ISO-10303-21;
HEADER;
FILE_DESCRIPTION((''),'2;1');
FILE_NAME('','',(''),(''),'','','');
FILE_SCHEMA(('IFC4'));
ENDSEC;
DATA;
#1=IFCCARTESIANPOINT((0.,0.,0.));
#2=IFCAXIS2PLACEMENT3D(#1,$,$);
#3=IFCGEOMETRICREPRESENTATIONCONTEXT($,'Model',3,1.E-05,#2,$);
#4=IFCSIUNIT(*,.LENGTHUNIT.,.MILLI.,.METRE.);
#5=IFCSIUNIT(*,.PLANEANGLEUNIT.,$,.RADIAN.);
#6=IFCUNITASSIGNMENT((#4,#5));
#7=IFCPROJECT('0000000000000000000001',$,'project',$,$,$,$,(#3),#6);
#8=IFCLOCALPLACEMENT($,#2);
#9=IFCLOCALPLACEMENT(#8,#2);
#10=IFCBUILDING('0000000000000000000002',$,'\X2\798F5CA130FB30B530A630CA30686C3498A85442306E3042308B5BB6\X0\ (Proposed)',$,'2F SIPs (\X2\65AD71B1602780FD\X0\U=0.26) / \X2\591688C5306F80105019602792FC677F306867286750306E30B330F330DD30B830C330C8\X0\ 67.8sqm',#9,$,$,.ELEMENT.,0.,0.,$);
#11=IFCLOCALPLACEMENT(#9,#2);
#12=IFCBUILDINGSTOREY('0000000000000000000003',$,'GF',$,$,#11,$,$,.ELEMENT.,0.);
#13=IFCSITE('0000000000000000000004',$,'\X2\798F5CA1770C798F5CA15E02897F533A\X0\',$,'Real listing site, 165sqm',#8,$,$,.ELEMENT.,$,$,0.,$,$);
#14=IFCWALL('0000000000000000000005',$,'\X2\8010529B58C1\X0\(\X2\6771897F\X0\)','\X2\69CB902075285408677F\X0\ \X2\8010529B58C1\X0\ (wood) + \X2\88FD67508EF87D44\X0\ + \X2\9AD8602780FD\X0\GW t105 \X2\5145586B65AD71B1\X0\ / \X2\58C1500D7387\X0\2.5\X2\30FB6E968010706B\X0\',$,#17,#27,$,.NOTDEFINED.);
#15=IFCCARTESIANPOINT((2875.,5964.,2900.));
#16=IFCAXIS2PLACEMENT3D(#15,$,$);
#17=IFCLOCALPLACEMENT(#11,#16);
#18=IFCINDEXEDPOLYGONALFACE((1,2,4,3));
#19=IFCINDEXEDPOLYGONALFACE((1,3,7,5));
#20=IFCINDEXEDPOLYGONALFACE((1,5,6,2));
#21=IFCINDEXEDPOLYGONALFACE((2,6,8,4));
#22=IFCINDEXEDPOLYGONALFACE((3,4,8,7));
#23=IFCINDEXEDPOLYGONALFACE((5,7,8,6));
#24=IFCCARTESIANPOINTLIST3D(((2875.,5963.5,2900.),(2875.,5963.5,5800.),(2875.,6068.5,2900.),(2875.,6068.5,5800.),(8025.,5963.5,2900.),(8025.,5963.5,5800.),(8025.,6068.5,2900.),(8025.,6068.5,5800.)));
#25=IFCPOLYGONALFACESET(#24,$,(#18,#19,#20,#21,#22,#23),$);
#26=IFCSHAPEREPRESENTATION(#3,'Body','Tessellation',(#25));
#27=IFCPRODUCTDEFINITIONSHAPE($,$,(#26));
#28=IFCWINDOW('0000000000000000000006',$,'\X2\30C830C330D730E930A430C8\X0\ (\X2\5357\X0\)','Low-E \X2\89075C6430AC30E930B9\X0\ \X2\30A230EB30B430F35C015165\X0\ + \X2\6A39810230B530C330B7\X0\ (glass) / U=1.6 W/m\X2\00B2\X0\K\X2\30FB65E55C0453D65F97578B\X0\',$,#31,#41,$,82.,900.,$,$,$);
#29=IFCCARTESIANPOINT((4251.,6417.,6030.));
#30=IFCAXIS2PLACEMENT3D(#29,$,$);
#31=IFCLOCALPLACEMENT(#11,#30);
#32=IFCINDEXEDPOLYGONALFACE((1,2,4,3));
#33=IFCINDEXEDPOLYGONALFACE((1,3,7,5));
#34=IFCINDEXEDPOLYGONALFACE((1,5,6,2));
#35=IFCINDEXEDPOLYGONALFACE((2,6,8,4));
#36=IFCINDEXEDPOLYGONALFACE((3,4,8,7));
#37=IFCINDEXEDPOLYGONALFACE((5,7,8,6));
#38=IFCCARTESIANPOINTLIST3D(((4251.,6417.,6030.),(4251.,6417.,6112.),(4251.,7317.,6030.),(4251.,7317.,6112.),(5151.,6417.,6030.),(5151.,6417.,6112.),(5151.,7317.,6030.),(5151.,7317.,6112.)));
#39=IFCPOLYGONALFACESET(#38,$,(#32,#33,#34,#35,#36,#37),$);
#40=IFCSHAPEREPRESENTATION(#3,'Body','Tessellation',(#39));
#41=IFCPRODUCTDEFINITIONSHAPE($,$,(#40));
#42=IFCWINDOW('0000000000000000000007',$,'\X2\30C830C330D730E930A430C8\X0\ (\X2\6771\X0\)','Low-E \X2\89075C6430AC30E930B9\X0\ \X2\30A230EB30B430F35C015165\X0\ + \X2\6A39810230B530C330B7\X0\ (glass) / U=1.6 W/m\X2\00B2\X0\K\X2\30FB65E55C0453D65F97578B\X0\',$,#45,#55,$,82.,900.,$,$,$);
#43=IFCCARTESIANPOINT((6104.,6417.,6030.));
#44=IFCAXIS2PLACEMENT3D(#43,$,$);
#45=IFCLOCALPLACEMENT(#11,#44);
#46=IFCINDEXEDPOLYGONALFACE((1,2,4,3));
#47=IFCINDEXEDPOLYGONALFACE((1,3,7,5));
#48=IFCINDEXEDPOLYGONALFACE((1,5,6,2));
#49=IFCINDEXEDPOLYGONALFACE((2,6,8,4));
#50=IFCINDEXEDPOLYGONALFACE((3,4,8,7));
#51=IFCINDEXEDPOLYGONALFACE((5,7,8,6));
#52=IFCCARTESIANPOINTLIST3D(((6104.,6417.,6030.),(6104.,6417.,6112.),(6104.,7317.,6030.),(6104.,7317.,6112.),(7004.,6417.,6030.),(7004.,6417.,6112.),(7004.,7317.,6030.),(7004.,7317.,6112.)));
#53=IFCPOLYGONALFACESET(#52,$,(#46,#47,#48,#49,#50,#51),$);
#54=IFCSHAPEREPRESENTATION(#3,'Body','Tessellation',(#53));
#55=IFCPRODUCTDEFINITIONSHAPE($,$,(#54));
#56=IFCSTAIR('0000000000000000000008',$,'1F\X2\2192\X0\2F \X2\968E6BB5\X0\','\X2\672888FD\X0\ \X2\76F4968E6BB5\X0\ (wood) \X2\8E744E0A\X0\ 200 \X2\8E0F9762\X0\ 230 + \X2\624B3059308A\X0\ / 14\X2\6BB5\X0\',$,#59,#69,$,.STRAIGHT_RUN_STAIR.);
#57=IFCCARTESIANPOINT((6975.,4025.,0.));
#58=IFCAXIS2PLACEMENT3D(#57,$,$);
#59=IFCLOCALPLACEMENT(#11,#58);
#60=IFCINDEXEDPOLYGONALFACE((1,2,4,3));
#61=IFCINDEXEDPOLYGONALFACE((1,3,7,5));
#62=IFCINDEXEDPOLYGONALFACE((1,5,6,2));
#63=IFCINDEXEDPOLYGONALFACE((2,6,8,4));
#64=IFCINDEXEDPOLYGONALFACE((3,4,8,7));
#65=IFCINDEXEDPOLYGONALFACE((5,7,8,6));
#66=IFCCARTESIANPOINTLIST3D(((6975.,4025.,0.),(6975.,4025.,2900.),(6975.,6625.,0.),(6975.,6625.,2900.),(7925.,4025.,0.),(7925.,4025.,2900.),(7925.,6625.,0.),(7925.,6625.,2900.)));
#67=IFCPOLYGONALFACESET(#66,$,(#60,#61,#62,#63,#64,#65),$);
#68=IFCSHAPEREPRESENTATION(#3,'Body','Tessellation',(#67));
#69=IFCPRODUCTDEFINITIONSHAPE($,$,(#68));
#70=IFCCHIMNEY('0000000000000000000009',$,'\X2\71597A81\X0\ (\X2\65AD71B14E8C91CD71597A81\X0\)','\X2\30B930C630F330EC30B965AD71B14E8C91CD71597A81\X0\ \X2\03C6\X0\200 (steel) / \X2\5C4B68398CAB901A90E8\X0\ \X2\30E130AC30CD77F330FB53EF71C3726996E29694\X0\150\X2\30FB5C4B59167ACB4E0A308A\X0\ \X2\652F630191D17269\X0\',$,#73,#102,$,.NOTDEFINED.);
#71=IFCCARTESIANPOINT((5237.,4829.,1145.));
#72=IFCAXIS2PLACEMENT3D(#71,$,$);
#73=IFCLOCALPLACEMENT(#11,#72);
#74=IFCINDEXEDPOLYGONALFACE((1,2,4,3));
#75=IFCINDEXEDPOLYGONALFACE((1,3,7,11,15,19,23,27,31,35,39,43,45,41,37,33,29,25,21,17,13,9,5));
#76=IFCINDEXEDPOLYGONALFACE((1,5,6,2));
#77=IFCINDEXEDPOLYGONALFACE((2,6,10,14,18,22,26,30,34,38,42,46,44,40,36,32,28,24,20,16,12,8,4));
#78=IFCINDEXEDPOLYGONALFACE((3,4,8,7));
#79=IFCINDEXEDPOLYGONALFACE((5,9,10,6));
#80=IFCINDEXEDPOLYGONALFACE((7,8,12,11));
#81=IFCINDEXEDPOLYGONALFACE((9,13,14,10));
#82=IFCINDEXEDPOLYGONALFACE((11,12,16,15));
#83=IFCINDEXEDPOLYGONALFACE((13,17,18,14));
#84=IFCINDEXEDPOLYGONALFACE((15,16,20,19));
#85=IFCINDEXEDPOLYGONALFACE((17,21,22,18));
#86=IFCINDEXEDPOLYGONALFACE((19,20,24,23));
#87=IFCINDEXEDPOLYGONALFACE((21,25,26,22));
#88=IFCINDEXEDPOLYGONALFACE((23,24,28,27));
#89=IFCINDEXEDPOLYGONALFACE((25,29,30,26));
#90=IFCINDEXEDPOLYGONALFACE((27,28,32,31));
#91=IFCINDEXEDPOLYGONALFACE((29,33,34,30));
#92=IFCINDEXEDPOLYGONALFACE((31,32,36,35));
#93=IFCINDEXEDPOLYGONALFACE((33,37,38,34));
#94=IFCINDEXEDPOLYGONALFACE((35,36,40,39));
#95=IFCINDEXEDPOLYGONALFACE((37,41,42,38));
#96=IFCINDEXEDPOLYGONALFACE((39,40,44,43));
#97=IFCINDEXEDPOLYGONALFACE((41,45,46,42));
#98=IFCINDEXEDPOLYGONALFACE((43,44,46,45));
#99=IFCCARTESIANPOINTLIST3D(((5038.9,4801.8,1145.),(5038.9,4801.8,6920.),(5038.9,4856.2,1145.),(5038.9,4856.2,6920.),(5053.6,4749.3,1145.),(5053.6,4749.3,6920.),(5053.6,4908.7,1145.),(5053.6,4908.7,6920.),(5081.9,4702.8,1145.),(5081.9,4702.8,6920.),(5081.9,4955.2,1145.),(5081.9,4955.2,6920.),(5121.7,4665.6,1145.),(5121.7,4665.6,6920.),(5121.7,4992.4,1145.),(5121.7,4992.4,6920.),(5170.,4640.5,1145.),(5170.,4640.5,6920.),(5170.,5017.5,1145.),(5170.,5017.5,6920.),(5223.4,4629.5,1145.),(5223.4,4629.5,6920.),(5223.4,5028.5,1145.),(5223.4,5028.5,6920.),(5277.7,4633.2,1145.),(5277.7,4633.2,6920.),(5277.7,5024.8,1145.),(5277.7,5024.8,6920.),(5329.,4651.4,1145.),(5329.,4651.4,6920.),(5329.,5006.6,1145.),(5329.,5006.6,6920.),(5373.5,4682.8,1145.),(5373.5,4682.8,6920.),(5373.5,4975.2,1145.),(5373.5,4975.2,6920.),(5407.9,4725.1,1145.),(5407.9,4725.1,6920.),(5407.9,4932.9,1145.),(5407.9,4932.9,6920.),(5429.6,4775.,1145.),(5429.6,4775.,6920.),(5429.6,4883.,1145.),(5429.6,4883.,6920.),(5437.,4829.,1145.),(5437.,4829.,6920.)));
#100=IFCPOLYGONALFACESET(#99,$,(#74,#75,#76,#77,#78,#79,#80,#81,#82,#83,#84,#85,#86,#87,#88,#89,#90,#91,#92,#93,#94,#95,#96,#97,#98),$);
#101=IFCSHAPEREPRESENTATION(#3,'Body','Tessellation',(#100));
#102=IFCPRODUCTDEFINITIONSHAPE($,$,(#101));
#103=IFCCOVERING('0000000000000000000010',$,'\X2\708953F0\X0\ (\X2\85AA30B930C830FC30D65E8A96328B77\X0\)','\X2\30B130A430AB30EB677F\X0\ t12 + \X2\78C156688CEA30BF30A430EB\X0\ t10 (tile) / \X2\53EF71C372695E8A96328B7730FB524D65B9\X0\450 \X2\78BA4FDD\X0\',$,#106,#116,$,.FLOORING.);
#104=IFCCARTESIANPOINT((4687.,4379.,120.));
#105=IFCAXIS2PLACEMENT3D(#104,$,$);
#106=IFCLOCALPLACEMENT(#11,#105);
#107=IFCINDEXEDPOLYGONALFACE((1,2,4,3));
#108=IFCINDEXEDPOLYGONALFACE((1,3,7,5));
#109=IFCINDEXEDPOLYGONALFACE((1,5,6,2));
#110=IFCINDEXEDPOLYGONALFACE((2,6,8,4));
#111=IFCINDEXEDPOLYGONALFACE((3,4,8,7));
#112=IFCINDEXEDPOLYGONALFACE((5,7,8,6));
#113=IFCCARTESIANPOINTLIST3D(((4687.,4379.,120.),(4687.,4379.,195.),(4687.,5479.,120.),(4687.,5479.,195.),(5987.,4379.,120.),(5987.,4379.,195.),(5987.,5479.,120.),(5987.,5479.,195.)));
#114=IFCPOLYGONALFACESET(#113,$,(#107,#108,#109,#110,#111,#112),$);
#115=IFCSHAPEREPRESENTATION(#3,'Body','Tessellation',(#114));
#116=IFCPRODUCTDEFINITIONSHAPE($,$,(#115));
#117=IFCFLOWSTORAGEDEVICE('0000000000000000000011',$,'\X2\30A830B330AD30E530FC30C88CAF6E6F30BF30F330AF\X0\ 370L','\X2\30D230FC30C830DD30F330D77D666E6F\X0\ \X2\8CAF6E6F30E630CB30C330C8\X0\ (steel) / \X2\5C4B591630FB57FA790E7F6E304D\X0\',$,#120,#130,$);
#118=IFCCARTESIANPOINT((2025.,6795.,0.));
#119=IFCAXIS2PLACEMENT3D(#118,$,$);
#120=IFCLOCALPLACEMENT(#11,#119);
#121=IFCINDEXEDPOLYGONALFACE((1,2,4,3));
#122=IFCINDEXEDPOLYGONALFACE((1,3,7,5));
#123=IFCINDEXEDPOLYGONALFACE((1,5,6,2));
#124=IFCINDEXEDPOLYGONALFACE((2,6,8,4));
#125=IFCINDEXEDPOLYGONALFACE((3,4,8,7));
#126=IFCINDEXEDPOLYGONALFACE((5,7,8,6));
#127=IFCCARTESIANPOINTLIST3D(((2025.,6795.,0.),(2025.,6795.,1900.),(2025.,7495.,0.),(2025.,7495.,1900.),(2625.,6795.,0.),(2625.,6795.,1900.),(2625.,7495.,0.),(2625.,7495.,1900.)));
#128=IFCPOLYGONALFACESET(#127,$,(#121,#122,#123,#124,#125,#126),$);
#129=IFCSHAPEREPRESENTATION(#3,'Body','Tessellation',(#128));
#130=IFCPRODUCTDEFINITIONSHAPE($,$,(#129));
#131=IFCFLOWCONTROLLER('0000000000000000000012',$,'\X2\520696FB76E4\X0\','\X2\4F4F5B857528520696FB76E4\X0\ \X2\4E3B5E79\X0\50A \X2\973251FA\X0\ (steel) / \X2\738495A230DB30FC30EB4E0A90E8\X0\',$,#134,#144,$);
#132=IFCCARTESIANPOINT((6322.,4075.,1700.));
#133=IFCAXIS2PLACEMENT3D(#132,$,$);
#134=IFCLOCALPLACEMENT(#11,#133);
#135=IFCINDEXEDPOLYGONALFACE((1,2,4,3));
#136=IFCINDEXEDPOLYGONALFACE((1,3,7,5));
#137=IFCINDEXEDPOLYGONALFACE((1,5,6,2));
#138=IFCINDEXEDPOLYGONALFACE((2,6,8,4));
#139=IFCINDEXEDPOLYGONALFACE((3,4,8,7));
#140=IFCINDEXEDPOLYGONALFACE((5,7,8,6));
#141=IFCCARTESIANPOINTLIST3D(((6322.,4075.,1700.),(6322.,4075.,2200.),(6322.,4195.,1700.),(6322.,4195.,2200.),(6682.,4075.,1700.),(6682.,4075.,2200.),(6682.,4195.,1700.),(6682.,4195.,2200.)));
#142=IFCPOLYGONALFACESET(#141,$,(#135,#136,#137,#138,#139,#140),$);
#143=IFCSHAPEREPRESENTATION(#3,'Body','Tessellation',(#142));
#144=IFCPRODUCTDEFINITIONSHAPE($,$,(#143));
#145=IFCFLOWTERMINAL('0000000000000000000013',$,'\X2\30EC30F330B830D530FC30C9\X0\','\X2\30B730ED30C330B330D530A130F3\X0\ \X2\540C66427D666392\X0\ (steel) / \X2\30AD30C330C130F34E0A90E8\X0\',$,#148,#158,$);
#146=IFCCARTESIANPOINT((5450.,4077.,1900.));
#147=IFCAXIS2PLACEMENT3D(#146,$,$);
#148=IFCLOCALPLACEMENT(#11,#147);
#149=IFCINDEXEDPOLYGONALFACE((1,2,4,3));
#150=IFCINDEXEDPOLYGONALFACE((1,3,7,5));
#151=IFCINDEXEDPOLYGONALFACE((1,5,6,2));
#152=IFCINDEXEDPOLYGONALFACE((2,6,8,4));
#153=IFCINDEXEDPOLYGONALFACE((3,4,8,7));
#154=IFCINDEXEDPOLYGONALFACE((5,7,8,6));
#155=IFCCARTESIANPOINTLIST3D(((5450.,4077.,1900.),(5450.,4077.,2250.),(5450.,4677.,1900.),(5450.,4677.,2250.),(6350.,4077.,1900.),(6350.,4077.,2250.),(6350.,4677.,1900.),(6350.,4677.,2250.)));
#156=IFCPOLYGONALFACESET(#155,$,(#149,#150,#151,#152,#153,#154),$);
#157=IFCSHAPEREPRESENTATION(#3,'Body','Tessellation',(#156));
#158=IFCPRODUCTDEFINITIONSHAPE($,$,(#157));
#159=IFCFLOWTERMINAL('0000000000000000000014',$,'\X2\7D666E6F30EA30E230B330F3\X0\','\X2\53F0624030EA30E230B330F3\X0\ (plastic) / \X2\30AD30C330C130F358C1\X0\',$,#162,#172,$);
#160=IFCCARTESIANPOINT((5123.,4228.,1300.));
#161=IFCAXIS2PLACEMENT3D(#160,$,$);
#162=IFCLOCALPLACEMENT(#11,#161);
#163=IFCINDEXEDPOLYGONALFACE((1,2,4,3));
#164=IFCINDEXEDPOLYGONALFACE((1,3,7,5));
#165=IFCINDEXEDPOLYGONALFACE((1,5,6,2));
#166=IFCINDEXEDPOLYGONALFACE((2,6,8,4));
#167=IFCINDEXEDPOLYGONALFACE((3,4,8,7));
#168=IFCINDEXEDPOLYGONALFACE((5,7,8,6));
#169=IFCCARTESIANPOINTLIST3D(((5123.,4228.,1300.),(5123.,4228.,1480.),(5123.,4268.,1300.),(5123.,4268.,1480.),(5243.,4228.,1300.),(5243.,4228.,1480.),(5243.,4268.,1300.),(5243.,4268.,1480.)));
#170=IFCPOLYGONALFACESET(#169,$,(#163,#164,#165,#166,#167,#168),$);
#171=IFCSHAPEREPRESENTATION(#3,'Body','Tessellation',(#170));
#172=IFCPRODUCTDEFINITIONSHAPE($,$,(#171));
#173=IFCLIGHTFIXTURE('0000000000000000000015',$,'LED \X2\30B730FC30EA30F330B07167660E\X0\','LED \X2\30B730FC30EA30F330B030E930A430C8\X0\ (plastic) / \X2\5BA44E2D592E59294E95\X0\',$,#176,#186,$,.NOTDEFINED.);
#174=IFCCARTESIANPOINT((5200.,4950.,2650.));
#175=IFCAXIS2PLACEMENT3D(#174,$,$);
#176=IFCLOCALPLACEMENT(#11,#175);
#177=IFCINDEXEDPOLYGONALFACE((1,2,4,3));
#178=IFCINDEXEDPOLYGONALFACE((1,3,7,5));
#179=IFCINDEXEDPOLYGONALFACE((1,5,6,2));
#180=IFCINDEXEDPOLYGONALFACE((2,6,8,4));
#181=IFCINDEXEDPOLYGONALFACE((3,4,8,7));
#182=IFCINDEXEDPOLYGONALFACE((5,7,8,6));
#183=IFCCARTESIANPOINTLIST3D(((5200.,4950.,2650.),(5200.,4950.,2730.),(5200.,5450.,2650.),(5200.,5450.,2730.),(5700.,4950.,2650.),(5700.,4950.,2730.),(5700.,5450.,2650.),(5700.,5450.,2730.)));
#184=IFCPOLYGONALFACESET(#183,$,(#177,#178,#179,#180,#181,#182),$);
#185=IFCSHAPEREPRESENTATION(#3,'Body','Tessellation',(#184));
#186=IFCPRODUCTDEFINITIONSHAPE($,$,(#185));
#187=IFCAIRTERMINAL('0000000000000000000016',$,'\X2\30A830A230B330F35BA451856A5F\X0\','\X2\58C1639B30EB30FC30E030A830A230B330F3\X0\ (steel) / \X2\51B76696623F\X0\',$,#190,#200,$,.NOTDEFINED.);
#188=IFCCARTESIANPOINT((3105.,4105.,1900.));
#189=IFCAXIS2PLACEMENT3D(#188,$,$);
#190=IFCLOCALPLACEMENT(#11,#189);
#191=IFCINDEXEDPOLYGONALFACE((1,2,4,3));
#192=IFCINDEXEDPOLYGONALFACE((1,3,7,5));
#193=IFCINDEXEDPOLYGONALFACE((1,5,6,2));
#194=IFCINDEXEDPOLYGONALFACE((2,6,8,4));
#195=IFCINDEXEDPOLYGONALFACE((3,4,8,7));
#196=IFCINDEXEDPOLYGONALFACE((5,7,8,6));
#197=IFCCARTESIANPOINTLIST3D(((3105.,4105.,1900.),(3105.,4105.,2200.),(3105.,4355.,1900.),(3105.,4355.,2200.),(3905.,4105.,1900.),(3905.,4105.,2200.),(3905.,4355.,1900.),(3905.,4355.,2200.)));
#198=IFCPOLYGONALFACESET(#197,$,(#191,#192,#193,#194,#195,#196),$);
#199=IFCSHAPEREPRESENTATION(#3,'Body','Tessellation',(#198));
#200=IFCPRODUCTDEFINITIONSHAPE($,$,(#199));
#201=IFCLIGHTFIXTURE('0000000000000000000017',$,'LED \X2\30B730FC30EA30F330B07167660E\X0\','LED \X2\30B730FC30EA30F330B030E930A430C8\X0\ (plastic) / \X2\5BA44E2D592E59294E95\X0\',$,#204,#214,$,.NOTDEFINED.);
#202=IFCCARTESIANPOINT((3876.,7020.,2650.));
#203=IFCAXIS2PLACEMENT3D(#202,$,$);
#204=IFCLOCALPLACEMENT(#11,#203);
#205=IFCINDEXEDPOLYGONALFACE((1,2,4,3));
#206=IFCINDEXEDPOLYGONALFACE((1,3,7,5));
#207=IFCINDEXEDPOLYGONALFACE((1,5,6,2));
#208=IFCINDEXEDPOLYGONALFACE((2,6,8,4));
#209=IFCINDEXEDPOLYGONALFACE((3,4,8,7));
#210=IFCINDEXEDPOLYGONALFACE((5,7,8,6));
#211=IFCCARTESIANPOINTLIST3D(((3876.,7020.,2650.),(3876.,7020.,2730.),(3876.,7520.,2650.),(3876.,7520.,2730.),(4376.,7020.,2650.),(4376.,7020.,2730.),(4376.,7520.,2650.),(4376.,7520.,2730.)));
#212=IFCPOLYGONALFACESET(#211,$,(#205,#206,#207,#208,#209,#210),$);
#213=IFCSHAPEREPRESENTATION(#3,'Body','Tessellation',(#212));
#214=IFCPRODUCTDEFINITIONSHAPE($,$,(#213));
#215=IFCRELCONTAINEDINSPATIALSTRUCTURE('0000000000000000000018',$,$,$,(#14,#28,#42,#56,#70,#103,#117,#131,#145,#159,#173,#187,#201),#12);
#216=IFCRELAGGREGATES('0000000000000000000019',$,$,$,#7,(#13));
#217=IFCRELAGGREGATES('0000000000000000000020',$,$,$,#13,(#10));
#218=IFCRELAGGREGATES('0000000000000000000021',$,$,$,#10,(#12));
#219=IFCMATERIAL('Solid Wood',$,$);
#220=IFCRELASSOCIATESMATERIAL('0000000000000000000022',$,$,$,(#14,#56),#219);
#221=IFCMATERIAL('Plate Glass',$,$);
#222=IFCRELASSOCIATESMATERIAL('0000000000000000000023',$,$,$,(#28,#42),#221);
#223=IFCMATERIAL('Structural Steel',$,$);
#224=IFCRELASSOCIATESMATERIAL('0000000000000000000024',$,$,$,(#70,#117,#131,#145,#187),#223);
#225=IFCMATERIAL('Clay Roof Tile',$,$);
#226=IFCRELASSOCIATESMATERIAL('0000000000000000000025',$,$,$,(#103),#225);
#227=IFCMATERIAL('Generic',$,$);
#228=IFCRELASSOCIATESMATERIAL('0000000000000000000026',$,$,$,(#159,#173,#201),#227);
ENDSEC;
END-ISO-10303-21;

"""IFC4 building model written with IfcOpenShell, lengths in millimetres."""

from ifc_helpers import new_model, si_unit, frame, frame_2d, origin, origin_2d, place, context, project, spatial, rectangle, circle, extrude, material, element, save


model = new_model("IFC4")

# Units and contexts
model_context = context("Model", 3, precision=1e-05, world=origin())
ifc_project = project(units=[si_unit("LENGTHUNIT", "METRE", prefix="MILLI"), si_unit("PLANEANGLEUNIT", "RADIAN")], contexts=[model_context])

# Site, building, storey
site_placement = place(None, origin())
site = spatial("IfcSite", under=ifc_project, at=site_placement, Name="福岡県福岡市西区", ObjectType="Real listing site, 165sqm", CompositionType="ELEMENT", RefElevation=0.0)
building_placement = place(site_placement, origin())
building = spatial("IfcBuilding", under=site, at=building_placement, Name="福岡・サウナと水風呂のある家 (Proposed)", ObjectType="2F SIPs (断熱性能U=0.26) / 外装は耐候性鋼板と木材のコンポジット 67.8sqm", CompositionType="ELEMENT", ElevationOfRefHeight=0.0, ElevationOfTerrain=0.0)
storey_placement = place(building_placement, origin())
storey = spatial("IfcBuildingStorey", under=building, at=storey_placement, Name="GF", CompositionType="ELEMENT", Elevation=0.0)

# Shared definitions
ifc_material_1 = material(Name="Solid Wood")

# Wall
wall_1_placement = place(storey_placement, frame((2875.0, 5964.0, 2900.0)))
element("IfcWall", 1, at=wall_1_placement, inside=storey, material=ifc_material_1, Name="耐力壁(東西)", Description="構造用合板 耐力壁 (wood) + 製材軸組 + 高性能GW t105 充填断熱 / 壁倍率2.5・準耐火", PredefinedType="NOTDEFINED", context=model_context, shape_type="SweptSolid", body=[
    extrude(rectangle(XDim=5150.0, YDim=105.0, at=frame_2d((2575.0, 52.0))), frame((2875.0, 5964.0, 2900.0)), (0.0, 0.0, 1.0), 2900.0),
])

# Windows
ifc_material_2 = material(Name="Plate Glass")
window_1_placement = place(storey_placement, frame((4251.0, 6417.0, 6030.0)))
element("IfcWindow", 2, at=window_1_placement, inside=storey, material=ifc_material_2, Name="トップライト (南)", Description="Low-E 複層ガラス アルゴン封入 + 樹脂サッシ (glass) / U=1.6 W/m²K・日射取得型", OverallHeight=82.0, OverallWidth=900.0, context=model_context, shape_type="SweptSolid", body=[
    extrude(rectangle(XDim=900.0, YDim=900.0, at=frame_2d((450.0, 450.0))), frame((4251.0, 6417.0, 6030.0)), (0.0, 0.0, 1.0), 82.0),
])
window_2_placement = place(storey_placement, frame((6104.0, 6417.0, 6030.0)))
element("IfcWindow", 3, at=window_2_placement, inside=storey, material=ifc_material_2, Name="トップライト (東)", Description="Low-E 複層ガラス アルゴン封入 + 樹脂サッシ (glass) / U=1.6 W/m²K・日射取得型", OverallHeight=82.0, OverallWidth=900.0, context=model_context, shape_type="SweptSolid", body=[
    extrude(rectangle(XDim=900.0, YDim=900.0, at=frame_2d((450.0, 450.0))), frame((6104.0, 6417.0, 6030.0)), (0.0, 0.0, 1.0), 82.0),
])

# Stair
stair_placement = place(storey_placement, frame((6975.0, 4025.0, 0.0)))
element("IfcStair", 4, at=stair_placement, inside=storey, material=ifc_material_1, Name="1F→2F 階段", Description="木製 直階段 (wood) 蹴上 200 踏面 230 + 手すり / 14段", PredefinedType="STRAIGHT_RUN_STAIR", context=model_context, shape_type="SweptSolid", body=[
    extrude(rectangle(XDim=950.0, YDim=2600.0, at=frame_2d((475.0, 1300.0))), frame((6975.0, 4025.0, 0.0)), (0.0, 0.0, 1.0), 2900.0),
])

# Chimney
ifc_material_3 = material(Name="Structural Steel")
chimney_placement = place(storey_placement, frame((5237.0, 4829.0, 1145.0)))
element("IfcChimney", 5, at=chimney_placement, inside=storey, material=ifc_material_3, Name="煙突 (断熱二重煙突)", Description="ステンレス断熱二重煙突 φ200 (steel) / 屋根貫通部 メガネ石・可燃物離隔150・屋外立上り 支持金物", PredefinedType="NOTDEFINED", context=model_context, shape_type="SweptSolid", body=[
    extrude(circle(Radius=200.0, at=origin_2d()), frame((5237.0, 4829.0, 1145.0)), (0.0, 0.0, 1.0), 5775.0),
])

# Covering
ifc_material_4 = material(Name="Clay Roof Tile")
covering_placement = place(storey_placement, frame((4687.0, 4379.0, 120.0)))
element("IfcCovering", 6, at=covering_placement, inside=storey, material=ifc_material_4, Name="炉台 (薪ストーブ床防護)", Description="ケイカル板 t12 + 磁器質タイル t10 (tile) / 可燃物床防護・前方450 確保", PredefinedType="FLOORING", context=model_context, shape_type="SweptSolid", body=[
    extrude(rectangle(XDim=1300.0, YDim=1100.0, at=frame_2d((650.0, 550.0))), frame((4687.0, 4379.0, 120.0)), (0.0, 0.0, 1.0), 75.0),
])

# Flow storage device
flow_storage_device_placement = place(storey_placement, frame((2025.0, 6795.0, 0.0)))
element("IfcFlowStorageDevice", 7, at=flow_storage_device_placement, inside=storey, material=ifc_material_3, Name="エコキュート貯湯タンク 370L", Description="ヒートポンプ給湯 貯湯ユニット (steel) / 屋外・基礎置き", context=model_context, shape_type="SweptSolid", body=[
    extrude(rectangle(XDim=600.0, YDim=700.0, at=frame_2d((300.0, 350.0))), frame((2025.0, 6795.0, 0.0)), (0.0, 0.0, 1.0), 1900.0),
])

# Flow controller
flow_controller_placement = place(storey_placement, frame((6322.0, 4075.0, 1700.0)))
element("IfcFlowController", 8, at=flow_controller_placement, inside=storey, material=ifc_material_3, Name="分電盤", Description="住宅用分電盤 主幹50A 露出 (steel) / 玄関ホール上部", context=model_context, shape_type="SweptSolid", body=[
    extrude(rectangle(XDim=360.0, YDim=120.0, at=frame_2d((180.0, 60.0))), frame((6322.0, 4075.0, 1700.0)), (0.0, 0.0, 1.0), 500.0),
])

# Flow terminals
flow_terminal_1_placement = place(storey_placement, frame((5450.0, 4077.0, 1900.0)))
element("IfcFlowTerminal", 9, at=flow_terminal_1_placement, inside=storey, material=ifc_material_3, Name="レンジフード", Description="シロッコファン 同時給排 (steel) / キッチン上部", context=model_context, shape_type="SweptSolid", body=[
    extrude(rectangle(XDim=900.0, YDim=600.0, at=frame_2d((450.0, 300.0))), frame((5450.0, 4077.0, 1900.0)), (0.0, 0.0, 1.0), 350.0),
])
ifc_material_5 = material(Name="Generic")
flow_terminal_2_placement = place(storey_placement, frame((5123.0, 4228.0, 1300.0)))
element("IfcFlowTerminal", 10, at=flow_terminal_2_placement, inside=storey, material=ifc_material_5, Name="給湯リモコン", Description="台所リモコン (plastic) / キッチン壁", context=model_context, shape_type="SweptSolid", body=[
    extrude(rectangle(XDim=120.0, YDim=40.0, at=frame_2d((60.0, 20.0))), frame((5123.0, 4228.0, 1300.0)), (0.0, 0.0, 1.0), 180.0),
])

# Light fixture
light_fixture_1_placement = place(storey_placement, frame((5200.0, 4950.0, 2650.0)))
element("IfcLightFixture", 11, at=light_fixture_1_placement, inside=storey, material=ifc_material_5, Name="LED シーリング照明", Description="LED シーリングライト (plastic) / 室中央天井", PredefinedType="NOTDEFINED", context=model_context, shape_type="SweptSolid", body=[
    extrude(rectangle(XDim=500.0, YDim=500.0, at=frame_2d((250.0, 250.0))), frame((5200.0, 4950.0, 2650.0)), (0.0, 0.0, 1.0), 80.0),
])

# Air terminal
air_terminal_1_placement = place(storey_placement, frame((3105.0, 4105.0, 1900.0)))
element("IfcAirTerminal", 12, at=air_terminal_1_placement, inside=storey, material=ifc_material_3, Name="エアコン室内機", Description="壁掛ルームエアコン (steel) / 冷暖房", PredefinedType="NOTDEFINED", context=model_context, shape_type="SweptSolid", body=[
    extrude(rectangle(XDim=800.0, YDim=250.0, at=frame_2d((400.0, 125.0))), frame((3105.0, 4105.0, 1900.0)), (0.0, 0.0, 1.0), 300.0),
])

# Light fixture
light_fixture_2_placement = place(storey_placement, frame((3876.0, 7020.0, 2650.0)))
element("IfcLightFixture", 13, at=light_fixture_2_placement, inside=storey, material=ifc_material_5, Name="LED シーリング照明", Description="LED シーリングライト (plastic) / 室中央天井", PredefinedType="NOTDEFINED", context=model_context, shape_type="SweptSolid", body=[
    extrude(rectangle(XDim=500.0, YDim=500.0, at=frame_2d((250.0, 250.0))), frame((3876.0, 7020.0, 2650.0)), (0.0, 0.0, 1.0), 80.0),
])

save(model, "model.ifc")
